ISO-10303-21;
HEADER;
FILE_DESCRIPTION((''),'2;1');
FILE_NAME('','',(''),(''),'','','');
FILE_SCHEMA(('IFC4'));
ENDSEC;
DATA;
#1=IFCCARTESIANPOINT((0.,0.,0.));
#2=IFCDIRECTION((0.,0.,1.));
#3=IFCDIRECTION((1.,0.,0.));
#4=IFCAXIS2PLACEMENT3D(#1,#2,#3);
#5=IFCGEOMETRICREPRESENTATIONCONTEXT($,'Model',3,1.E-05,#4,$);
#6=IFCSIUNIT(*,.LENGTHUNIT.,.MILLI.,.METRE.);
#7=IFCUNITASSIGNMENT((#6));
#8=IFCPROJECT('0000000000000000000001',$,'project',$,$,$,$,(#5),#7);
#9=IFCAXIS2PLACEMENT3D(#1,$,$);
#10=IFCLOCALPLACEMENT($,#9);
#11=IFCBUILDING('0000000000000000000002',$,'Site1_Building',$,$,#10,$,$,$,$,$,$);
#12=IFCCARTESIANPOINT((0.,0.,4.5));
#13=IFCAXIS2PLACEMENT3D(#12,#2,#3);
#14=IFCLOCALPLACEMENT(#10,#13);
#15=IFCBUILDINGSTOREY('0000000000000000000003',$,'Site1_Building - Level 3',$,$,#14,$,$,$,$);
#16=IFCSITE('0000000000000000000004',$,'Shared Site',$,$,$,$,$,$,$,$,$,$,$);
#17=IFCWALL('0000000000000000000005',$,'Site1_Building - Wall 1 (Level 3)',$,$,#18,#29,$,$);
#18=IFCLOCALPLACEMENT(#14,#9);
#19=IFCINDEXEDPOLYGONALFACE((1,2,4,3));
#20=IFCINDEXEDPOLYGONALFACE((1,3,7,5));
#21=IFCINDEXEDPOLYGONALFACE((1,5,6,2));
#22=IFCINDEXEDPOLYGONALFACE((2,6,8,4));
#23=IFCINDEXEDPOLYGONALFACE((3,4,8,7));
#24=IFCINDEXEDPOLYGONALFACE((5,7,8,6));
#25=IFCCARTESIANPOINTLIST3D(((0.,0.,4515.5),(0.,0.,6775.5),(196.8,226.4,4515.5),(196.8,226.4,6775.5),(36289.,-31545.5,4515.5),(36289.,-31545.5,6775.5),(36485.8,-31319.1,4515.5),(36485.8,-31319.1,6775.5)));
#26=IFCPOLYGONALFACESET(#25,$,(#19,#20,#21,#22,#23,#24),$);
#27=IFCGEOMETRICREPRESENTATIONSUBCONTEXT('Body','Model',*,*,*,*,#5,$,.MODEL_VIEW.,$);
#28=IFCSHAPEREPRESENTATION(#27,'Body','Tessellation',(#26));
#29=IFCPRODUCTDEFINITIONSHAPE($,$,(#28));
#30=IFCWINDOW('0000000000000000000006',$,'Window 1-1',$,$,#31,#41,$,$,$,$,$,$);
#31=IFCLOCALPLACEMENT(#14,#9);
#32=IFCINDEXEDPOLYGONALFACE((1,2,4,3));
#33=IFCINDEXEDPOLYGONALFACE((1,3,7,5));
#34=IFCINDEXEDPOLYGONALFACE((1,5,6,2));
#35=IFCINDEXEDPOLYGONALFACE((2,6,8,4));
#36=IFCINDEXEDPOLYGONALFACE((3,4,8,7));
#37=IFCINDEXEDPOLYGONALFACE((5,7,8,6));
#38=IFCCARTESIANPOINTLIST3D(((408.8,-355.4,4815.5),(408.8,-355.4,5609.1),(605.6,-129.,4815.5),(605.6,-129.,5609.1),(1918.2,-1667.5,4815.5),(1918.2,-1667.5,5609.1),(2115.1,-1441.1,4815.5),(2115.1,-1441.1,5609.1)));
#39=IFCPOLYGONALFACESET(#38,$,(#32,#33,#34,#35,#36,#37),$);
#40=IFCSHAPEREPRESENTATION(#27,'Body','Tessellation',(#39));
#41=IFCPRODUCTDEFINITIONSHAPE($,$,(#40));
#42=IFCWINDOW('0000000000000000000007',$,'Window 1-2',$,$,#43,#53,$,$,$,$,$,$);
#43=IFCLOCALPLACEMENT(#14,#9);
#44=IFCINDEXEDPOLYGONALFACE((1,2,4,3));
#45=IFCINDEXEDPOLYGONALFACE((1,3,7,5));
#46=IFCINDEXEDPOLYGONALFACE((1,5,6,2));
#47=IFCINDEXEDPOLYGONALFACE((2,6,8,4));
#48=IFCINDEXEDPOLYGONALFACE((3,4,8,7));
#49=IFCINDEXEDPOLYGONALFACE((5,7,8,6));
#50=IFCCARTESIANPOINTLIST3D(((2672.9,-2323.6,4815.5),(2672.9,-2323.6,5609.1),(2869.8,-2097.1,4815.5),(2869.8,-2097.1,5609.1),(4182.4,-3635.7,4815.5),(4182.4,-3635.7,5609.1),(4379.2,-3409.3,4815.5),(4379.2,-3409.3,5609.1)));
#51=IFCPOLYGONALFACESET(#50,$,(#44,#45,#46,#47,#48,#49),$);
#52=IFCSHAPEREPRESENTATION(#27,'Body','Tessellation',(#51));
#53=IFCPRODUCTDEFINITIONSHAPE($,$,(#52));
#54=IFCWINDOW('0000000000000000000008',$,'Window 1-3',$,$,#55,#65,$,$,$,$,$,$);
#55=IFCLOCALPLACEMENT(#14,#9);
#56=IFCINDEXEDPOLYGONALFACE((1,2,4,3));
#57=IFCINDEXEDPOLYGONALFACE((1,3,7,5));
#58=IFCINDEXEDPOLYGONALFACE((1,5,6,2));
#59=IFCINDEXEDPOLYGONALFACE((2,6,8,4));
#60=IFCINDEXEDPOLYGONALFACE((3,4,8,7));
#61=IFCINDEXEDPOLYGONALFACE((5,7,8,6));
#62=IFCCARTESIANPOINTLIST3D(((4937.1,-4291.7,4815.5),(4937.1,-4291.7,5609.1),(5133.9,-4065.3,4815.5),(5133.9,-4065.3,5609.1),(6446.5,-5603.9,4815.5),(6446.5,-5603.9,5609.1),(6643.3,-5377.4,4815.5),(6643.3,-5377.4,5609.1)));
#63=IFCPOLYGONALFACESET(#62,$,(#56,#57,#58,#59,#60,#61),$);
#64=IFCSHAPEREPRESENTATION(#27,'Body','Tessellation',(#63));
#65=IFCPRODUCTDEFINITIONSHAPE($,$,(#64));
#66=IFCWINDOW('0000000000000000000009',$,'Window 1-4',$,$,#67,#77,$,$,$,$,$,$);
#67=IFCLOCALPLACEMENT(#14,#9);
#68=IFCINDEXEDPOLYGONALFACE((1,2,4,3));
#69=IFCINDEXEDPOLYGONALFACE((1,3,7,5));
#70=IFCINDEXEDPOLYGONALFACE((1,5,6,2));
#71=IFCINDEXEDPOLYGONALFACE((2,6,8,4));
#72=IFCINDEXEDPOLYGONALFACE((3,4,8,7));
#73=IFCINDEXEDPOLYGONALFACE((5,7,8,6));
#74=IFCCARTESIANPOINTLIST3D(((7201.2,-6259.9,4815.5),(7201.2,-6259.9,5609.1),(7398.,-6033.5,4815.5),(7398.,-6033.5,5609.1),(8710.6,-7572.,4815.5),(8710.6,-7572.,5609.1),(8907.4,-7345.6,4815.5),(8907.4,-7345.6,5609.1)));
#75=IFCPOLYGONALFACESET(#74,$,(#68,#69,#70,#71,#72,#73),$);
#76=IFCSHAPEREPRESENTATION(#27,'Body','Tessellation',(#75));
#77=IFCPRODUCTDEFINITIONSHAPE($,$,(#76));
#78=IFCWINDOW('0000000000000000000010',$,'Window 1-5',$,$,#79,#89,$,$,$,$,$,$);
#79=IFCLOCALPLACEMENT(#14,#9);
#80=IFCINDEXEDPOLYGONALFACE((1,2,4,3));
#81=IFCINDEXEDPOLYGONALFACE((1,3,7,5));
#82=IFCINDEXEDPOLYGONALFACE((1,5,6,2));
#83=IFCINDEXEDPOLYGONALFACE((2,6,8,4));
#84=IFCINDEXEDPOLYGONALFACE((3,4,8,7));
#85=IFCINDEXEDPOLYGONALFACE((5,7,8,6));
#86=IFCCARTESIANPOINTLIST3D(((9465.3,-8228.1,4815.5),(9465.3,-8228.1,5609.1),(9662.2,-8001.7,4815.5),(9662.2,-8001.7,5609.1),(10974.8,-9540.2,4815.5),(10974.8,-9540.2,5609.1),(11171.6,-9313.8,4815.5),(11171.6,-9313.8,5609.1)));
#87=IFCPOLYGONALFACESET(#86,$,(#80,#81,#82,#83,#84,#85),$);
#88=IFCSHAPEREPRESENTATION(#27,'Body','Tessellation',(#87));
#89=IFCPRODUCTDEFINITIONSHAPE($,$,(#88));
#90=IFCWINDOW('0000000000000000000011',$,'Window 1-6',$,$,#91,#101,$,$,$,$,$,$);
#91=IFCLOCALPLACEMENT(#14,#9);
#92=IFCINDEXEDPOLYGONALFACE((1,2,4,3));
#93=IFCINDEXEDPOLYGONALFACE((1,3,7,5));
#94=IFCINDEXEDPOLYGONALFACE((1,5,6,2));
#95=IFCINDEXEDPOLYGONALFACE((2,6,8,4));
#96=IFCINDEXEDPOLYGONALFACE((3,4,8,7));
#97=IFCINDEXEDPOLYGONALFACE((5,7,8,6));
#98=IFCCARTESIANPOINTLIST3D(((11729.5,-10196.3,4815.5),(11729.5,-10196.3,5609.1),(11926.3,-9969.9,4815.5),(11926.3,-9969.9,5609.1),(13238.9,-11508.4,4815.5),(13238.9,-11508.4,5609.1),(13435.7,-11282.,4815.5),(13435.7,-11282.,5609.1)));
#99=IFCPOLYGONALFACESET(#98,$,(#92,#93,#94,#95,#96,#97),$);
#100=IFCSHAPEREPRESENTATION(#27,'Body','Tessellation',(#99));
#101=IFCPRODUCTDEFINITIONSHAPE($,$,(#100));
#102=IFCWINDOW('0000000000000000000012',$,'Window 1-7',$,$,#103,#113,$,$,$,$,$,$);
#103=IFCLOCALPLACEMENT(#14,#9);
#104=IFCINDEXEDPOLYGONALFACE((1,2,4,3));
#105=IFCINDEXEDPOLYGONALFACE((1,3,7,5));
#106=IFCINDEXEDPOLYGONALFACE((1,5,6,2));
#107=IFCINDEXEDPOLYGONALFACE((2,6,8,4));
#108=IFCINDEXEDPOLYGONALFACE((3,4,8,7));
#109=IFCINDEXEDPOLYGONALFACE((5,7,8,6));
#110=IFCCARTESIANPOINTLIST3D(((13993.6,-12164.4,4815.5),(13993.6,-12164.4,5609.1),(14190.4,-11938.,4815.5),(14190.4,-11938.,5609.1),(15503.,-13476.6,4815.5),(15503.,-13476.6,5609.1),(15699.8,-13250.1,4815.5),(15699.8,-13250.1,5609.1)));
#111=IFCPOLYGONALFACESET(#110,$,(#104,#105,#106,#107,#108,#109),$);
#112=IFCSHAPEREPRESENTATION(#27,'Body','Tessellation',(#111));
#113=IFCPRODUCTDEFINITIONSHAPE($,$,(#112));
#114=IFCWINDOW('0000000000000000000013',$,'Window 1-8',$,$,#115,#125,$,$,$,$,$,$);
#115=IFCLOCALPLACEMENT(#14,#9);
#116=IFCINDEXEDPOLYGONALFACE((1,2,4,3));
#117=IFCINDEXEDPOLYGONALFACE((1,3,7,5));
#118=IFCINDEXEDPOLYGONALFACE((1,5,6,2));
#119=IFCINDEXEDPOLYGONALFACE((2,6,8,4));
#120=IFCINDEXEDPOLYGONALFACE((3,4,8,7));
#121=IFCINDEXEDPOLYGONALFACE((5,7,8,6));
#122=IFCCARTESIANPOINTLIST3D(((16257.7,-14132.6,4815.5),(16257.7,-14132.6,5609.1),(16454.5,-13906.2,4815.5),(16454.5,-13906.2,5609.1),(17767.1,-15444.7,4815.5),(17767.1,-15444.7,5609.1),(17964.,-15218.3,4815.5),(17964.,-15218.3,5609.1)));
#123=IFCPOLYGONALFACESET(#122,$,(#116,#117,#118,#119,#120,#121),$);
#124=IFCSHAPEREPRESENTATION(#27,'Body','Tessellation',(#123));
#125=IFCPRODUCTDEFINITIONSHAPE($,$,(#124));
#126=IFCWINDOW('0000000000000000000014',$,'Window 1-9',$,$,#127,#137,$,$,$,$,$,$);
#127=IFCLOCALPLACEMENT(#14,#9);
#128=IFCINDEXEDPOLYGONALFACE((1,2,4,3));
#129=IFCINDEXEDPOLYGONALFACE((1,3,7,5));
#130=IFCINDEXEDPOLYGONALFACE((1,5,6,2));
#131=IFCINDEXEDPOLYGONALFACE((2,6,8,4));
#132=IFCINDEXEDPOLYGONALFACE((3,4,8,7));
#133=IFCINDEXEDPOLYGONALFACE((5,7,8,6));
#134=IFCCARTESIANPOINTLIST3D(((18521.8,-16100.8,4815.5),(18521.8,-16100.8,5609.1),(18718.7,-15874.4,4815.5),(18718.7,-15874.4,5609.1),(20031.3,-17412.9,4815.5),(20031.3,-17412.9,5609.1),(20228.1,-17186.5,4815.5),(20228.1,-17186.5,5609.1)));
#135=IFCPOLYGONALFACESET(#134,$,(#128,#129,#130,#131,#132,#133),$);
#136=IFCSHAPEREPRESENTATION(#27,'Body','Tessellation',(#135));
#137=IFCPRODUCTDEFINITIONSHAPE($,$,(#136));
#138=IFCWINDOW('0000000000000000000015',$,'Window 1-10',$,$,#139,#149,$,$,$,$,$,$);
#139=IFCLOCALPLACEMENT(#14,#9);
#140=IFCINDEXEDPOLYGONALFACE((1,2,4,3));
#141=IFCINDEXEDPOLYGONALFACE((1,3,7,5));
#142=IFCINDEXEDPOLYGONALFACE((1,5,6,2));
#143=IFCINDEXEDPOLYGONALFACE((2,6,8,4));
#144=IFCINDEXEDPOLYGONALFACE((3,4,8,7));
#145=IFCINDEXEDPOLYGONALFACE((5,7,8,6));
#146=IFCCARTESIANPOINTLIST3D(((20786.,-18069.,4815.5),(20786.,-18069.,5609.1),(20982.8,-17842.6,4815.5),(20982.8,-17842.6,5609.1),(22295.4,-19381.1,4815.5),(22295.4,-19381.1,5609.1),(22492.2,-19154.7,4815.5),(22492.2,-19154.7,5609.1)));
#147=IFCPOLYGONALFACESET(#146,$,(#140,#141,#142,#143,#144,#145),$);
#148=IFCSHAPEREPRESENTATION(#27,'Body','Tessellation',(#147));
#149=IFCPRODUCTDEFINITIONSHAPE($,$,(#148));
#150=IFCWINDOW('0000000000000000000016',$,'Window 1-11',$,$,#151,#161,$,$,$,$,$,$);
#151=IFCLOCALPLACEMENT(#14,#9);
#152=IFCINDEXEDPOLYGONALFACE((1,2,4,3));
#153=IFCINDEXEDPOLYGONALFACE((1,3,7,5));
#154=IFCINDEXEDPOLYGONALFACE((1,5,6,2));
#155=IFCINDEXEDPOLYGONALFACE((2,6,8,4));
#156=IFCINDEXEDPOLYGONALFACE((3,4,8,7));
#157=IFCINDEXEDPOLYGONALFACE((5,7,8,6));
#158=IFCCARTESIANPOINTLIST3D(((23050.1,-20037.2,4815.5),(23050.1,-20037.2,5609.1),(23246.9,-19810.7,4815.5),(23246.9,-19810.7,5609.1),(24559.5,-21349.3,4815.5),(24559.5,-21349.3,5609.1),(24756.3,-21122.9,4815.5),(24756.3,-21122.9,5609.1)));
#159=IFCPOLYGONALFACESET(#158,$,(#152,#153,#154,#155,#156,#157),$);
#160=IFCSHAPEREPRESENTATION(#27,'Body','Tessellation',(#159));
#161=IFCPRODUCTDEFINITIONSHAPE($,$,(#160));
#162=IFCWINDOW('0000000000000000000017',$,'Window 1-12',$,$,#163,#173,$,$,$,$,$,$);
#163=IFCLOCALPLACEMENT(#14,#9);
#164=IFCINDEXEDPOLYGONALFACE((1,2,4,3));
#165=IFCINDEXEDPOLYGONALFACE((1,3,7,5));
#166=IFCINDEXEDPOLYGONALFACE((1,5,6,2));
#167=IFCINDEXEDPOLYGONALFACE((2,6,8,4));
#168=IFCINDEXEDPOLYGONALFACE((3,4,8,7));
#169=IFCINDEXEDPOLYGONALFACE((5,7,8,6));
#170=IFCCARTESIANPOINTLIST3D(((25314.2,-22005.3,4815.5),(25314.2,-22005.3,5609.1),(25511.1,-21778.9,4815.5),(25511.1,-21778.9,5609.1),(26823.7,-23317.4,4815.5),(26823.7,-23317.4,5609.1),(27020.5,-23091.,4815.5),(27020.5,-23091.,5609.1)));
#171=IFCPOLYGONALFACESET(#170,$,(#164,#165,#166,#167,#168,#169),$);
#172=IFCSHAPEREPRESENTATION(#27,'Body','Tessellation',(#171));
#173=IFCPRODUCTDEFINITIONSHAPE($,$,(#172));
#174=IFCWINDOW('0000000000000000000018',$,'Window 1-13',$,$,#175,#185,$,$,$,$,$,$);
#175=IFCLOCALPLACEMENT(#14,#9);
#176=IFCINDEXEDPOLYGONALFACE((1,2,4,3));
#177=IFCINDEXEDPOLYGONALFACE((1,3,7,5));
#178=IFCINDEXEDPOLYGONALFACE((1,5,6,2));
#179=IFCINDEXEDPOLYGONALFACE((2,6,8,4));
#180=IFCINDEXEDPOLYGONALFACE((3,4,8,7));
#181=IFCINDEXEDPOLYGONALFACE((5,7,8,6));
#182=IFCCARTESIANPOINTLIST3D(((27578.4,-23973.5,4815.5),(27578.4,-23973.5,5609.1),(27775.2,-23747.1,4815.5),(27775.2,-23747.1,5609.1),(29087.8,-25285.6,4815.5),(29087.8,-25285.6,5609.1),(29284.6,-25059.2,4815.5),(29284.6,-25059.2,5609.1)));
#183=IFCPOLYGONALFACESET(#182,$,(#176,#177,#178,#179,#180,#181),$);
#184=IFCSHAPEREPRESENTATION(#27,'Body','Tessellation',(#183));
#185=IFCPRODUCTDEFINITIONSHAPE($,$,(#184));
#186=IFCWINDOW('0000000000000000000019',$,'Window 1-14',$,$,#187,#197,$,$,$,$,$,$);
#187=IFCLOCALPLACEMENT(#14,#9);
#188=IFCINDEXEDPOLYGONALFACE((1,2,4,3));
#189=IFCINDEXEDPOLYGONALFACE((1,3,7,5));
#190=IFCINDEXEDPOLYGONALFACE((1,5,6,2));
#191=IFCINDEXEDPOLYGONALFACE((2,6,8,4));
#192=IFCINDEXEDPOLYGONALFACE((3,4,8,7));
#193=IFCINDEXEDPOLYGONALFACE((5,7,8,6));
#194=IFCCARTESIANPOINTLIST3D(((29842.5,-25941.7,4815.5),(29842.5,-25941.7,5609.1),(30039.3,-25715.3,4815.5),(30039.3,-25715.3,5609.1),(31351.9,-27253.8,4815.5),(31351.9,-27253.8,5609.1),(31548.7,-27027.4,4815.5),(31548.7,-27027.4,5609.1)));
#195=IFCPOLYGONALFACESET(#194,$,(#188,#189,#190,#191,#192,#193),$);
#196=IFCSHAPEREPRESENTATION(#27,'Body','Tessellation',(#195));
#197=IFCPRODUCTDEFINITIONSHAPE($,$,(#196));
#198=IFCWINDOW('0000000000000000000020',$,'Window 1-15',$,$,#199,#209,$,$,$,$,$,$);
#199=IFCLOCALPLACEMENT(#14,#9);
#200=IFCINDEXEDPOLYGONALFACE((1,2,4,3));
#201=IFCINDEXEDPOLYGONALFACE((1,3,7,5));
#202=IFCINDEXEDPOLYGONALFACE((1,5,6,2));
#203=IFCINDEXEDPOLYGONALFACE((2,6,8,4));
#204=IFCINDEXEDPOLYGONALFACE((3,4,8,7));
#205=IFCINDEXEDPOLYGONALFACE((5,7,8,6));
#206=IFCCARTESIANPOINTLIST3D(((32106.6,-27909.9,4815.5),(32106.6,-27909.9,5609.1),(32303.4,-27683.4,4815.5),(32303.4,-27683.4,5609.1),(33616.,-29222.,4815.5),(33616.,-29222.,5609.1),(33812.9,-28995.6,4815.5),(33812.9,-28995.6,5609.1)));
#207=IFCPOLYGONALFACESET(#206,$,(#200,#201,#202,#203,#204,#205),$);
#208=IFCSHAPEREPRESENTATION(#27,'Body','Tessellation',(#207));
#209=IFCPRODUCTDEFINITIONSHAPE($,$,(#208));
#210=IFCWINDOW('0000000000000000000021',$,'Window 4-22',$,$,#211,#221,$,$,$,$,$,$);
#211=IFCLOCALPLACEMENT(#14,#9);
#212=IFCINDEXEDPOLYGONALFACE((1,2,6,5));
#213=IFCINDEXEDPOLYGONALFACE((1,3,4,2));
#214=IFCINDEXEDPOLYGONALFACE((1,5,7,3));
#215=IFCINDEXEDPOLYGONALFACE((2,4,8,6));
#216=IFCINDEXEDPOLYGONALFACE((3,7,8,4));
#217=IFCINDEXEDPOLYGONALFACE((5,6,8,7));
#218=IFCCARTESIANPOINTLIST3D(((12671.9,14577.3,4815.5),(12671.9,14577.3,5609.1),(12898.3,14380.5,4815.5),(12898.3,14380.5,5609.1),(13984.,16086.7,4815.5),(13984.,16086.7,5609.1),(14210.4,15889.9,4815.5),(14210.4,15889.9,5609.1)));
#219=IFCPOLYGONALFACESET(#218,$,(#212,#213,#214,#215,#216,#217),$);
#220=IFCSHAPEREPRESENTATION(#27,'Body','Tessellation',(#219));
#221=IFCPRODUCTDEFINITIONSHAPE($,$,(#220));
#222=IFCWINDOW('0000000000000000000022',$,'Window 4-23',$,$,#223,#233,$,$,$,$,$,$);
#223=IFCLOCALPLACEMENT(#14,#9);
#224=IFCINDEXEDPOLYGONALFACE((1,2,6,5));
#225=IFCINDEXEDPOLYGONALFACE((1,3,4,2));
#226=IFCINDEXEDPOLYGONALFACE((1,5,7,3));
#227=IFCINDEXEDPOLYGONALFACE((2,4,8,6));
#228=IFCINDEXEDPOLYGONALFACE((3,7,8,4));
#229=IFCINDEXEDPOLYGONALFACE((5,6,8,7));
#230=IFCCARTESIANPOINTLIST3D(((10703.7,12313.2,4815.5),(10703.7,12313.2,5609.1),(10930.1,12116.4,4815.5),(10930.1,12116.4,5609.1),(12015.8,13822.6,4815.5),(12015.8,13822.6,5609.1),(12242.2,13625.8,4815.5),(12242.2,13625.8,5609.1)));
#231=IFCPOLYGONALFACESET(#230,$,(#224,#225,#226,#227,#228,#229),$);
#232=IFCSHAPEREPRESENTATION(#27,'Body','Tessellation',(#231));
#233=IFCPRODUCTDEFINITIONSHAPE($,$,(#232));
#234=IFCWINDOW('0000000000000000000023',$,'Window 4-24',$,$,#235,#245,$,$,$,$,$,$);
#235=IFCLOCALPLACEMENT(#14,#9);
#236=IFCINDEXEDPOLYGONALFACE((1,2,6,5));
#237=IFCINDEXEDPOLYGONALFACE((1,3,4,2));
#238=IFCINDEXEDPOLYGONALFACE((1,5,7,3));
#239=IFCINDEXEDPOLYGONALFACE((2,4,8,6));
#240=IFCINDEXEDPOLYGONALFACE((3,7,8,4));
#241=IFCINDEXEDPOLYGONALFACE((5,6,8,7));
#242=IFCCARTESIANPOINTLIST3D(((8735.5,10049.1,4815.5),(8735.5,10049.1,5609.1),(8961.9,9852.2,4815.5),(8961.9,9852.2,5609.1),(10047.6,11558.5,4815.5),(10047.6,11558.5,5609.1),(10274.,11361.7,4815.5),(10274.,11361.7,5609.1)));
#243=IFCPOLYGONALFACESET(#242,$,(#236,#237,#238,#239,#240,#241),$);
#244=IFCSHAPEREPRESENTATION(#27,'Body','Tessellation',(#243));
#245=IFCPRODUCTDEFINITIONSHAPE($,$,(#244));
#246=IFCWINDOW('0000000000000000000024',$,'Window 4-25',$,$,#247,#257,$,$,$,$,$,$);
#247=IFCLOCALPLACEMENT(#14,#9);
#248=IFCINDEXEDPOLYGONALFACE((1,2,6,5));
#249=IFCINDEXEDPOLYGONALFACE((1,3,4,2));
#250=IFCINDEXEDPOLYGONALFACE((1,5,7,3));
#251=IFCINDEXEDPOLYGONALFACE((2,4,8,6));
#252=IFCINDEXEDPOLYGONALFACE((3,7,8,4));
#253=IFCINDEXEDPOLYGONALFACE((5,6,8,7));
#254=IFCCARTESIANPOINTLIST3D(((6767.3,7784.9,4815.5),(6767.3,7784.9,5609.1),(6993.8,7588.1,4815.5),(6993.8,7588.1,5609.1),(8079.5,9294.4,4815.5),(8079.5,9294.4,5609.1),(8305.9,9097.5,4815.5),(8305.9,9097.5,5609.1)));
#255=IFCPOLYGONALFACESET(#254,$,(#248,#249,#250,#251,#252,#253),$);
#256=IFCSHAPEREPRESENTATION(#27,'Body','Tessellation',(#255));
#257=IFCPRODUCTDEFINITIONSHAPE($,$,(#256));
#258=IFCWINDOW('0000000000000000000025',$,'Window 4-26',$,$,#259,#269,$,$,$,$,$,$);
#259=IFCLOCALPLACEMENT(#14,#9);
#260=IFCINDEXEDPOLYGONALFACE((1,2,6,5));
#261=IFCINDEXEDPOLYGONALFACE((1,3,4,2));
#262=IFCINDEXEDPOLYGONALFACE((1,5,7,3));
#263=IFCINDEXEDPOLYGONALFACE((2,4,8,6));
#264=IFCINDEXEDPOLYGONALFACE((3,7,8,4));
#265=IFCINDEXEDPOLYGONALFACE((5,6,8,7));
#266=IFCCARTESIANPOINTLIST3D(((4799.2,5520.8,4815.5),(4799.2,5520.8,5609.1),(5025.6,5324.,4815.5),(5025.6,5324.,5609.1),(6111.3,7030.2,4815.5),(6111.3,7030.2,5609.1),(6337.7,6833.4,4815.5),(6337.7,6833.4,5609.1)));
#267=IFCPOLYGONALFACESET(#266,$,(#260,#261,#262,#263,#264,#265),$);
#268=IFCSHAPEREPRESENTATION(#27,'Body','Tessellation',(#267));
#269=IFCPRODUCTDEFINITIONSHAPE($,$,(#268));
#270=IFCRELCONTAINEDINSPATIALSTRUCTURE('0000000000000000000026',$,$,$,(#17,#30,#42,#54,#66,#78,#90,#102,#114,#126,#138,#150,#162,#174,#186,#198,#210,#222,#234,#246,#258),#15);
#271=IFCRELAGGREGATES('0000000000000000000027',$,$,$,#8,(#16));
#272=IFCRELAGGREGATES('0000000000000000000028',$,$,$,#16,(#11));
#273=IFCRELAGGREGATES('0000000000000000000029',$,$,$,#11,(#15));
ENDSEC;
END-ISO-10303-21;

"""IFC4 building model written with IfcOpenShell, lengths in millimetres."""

from ifc_helpers import new_model, si_unit, frame, origin, origin_with_axes, place, context, subcontext, project, spatial, indexed_curve, outline, extrude, element, save


model = new_model("IFC4")

# Units and contexts
model_context = context("Model", 3, precision=1e-05, world=origin_with_axes())
body_context = subcontext(model_context, "Body", "Model", "MODEL_VIEW")
ifc_project = project(units=[si_unit("LENGTHUNIT", "METRE", prefix="MILLI")], contexts=[model_context])

# Site, building, storey
site = spatial("IfcSite", under=ifc_project, Name="Shared Site")
building_placement = place(None, origin())
building = spatial("IfcBuilding", under=site, at=building_placement, Name="Site1_Building")
storey_placement = place(building_placement, frame((0.0, 0.0, 4.5), z_axis=(0.0, 0.0, 1.0), x_axis=(1.0, 0.0, 0.0)))
storey = spatial("IfcBuildingStorey", under=building, at=storey_placement, Name="Site1_Building - Level 3")

# Wall
wall_placement = place(storey_placement, frame((0.0, 0.0, 4515.5), z_axis=(0.0, 0.0, 1.0), x_axis=(0.75471, -0.656059, 0.0)))
element("IfcWall", 1, at=wall_placement, inside=storey, Name="Site1_Building - Wall 1 (Level 3)", context=body_context, shape_type="SweptSolid", body=[
    extrude(outline(indexed_curve([(0.0, 0.0), (0.0, 300.0), (48083.4, 300.0), (48083.4, 0.0), (0.0, 0.0)], self_intersect=False)), origin_with_axes(), (0.0, 0.0, 1.0), 2260.0),
])

# Windows
for number, where, z_axis, x_axis, name in (
    (2, (408.8, -355.4, 4815.5), (0.0, 0.0, 1.0), (0.75471, -0.656059, 0.0), "Window 1-1"),
    (3, (2672.9, -2323.6, 4815.5), (0.0, 0.0, 1.0), (0.75471, -0.656059, 0.0), "Window 1-2"),
    (4, (4937.1, -4291.7, 4815.5), (0.0, 0.0, 1.0), (0.75471, -0.656059, 0.0), "Window 1-3"),
    (5, (7201.2, -6259.9, 4815.5), (0.0, 0.0, 1.0), (0.75471, -0.656059, 0.0), "Window 1-4"),
    (6, (9465.3, -8228.1, 4815.5), (0.0, 0.0, 1.0), (0.75471, -0.656059, 0.0), "Window 1-5"),
    (7, (11729.5, -10196.3, 4815.5), (0.0, 0.0, 1.0), (0.75471, -0.656059, 0.0), "Window 1-6"),
    (8, (13993.6, -12164.4, 4815.5), (0.0, 0.0, 1.0), (0.75471, -0.656059, 0.0), "Window 1-7"),
    (9, (16257.7, -14132.6, 4815.5), (0.0, 0.0, 1.0), (0.75471, -0.656059, 0.0), "Window 1-8"),
    (10, (18521.8, -16100.8, 4815.5), (0.0, 0.0, 1.0), (0.75471, -0.656059, 0.0), "Window 1-9"),
    (11, (20786.0, -18069.0, 4815.5), (0.0, 0.0, 1.0), (0.75471, -0.656059, 0.0), "Window 1-10"),
    (12, (23050.1, -20037.2, 4815.5), (0.0, 0.0, 1.0), (0.75471, -0.656059, 0.0), "Window 1-11"),
    (13, (25314.2, -22005.3, 4815.5), (0.0, 0.0, 1.0), (0.75471, -0.656059, 0.0), "Window 1-12"),
    (14, (27578.4, -23973.5, 4815.5), (0.0, 0.0, 1.0), (0.75471, -0.656059, 0.0), "Window 1-13"),
    (15, (29842.5, -25941.7, 4815.5), (0.0, 0.0, 1.0), (0.75471, -0.656059, 0.0), "Window 1-14"),
    (16, (32106.6, -27909.9, 4815.5), (0.0, 0.0, 1.0), (0.75471, -0.656059, 0.0), "Window 1-15"),
    (17, (13984.0, 16086.7, 4815.5), (0.0, 0.0, 1.0), (-0.656059, -0.75471, 0.0), "Window 4-22"),
    (18, (12015.8, 13822.6, 4815.5), (0.0, 0.0, 1.0), (-0.656059, -0.75471, 0.0), "Window 4-23"),
    (19, (10047.6, 11558.5, 4815.5), (0.0, 0.0, 1.0), (-0.656059, -0.75471, 0.0), "Window 4-24"),
    (20, (8079.5, 9294.4, 4815.5), (0.0, 0.0, 1.0), (-0.656059, -0.75471, 0.0), "Window 4-25"),
    (21, (6111.3, 7030.2, 4815.5), (0.0, 0.0, 1.0), (-0.656059, -0.75471, 0.0), "Window 4-26"),
):
    element("IfcWindow", number, at=place(storey_placement, frame(where, z_axis=z_axis, x_axis=x_axis)), inside=storey, Name=name, context=body_context, shape_type="SweptSolid", body=[
        extrude(outline(indexed_curve([(0.0, 0.0), (0.0, 300.0), (2000.0, 300.0), (2000.0, 0.0), (0.0, 0.0)], self_intersect=False)), origin_with_axes(), (0.0, 0.0, 1.0), 793.6),
    ])

save(model, "model.ifc")
